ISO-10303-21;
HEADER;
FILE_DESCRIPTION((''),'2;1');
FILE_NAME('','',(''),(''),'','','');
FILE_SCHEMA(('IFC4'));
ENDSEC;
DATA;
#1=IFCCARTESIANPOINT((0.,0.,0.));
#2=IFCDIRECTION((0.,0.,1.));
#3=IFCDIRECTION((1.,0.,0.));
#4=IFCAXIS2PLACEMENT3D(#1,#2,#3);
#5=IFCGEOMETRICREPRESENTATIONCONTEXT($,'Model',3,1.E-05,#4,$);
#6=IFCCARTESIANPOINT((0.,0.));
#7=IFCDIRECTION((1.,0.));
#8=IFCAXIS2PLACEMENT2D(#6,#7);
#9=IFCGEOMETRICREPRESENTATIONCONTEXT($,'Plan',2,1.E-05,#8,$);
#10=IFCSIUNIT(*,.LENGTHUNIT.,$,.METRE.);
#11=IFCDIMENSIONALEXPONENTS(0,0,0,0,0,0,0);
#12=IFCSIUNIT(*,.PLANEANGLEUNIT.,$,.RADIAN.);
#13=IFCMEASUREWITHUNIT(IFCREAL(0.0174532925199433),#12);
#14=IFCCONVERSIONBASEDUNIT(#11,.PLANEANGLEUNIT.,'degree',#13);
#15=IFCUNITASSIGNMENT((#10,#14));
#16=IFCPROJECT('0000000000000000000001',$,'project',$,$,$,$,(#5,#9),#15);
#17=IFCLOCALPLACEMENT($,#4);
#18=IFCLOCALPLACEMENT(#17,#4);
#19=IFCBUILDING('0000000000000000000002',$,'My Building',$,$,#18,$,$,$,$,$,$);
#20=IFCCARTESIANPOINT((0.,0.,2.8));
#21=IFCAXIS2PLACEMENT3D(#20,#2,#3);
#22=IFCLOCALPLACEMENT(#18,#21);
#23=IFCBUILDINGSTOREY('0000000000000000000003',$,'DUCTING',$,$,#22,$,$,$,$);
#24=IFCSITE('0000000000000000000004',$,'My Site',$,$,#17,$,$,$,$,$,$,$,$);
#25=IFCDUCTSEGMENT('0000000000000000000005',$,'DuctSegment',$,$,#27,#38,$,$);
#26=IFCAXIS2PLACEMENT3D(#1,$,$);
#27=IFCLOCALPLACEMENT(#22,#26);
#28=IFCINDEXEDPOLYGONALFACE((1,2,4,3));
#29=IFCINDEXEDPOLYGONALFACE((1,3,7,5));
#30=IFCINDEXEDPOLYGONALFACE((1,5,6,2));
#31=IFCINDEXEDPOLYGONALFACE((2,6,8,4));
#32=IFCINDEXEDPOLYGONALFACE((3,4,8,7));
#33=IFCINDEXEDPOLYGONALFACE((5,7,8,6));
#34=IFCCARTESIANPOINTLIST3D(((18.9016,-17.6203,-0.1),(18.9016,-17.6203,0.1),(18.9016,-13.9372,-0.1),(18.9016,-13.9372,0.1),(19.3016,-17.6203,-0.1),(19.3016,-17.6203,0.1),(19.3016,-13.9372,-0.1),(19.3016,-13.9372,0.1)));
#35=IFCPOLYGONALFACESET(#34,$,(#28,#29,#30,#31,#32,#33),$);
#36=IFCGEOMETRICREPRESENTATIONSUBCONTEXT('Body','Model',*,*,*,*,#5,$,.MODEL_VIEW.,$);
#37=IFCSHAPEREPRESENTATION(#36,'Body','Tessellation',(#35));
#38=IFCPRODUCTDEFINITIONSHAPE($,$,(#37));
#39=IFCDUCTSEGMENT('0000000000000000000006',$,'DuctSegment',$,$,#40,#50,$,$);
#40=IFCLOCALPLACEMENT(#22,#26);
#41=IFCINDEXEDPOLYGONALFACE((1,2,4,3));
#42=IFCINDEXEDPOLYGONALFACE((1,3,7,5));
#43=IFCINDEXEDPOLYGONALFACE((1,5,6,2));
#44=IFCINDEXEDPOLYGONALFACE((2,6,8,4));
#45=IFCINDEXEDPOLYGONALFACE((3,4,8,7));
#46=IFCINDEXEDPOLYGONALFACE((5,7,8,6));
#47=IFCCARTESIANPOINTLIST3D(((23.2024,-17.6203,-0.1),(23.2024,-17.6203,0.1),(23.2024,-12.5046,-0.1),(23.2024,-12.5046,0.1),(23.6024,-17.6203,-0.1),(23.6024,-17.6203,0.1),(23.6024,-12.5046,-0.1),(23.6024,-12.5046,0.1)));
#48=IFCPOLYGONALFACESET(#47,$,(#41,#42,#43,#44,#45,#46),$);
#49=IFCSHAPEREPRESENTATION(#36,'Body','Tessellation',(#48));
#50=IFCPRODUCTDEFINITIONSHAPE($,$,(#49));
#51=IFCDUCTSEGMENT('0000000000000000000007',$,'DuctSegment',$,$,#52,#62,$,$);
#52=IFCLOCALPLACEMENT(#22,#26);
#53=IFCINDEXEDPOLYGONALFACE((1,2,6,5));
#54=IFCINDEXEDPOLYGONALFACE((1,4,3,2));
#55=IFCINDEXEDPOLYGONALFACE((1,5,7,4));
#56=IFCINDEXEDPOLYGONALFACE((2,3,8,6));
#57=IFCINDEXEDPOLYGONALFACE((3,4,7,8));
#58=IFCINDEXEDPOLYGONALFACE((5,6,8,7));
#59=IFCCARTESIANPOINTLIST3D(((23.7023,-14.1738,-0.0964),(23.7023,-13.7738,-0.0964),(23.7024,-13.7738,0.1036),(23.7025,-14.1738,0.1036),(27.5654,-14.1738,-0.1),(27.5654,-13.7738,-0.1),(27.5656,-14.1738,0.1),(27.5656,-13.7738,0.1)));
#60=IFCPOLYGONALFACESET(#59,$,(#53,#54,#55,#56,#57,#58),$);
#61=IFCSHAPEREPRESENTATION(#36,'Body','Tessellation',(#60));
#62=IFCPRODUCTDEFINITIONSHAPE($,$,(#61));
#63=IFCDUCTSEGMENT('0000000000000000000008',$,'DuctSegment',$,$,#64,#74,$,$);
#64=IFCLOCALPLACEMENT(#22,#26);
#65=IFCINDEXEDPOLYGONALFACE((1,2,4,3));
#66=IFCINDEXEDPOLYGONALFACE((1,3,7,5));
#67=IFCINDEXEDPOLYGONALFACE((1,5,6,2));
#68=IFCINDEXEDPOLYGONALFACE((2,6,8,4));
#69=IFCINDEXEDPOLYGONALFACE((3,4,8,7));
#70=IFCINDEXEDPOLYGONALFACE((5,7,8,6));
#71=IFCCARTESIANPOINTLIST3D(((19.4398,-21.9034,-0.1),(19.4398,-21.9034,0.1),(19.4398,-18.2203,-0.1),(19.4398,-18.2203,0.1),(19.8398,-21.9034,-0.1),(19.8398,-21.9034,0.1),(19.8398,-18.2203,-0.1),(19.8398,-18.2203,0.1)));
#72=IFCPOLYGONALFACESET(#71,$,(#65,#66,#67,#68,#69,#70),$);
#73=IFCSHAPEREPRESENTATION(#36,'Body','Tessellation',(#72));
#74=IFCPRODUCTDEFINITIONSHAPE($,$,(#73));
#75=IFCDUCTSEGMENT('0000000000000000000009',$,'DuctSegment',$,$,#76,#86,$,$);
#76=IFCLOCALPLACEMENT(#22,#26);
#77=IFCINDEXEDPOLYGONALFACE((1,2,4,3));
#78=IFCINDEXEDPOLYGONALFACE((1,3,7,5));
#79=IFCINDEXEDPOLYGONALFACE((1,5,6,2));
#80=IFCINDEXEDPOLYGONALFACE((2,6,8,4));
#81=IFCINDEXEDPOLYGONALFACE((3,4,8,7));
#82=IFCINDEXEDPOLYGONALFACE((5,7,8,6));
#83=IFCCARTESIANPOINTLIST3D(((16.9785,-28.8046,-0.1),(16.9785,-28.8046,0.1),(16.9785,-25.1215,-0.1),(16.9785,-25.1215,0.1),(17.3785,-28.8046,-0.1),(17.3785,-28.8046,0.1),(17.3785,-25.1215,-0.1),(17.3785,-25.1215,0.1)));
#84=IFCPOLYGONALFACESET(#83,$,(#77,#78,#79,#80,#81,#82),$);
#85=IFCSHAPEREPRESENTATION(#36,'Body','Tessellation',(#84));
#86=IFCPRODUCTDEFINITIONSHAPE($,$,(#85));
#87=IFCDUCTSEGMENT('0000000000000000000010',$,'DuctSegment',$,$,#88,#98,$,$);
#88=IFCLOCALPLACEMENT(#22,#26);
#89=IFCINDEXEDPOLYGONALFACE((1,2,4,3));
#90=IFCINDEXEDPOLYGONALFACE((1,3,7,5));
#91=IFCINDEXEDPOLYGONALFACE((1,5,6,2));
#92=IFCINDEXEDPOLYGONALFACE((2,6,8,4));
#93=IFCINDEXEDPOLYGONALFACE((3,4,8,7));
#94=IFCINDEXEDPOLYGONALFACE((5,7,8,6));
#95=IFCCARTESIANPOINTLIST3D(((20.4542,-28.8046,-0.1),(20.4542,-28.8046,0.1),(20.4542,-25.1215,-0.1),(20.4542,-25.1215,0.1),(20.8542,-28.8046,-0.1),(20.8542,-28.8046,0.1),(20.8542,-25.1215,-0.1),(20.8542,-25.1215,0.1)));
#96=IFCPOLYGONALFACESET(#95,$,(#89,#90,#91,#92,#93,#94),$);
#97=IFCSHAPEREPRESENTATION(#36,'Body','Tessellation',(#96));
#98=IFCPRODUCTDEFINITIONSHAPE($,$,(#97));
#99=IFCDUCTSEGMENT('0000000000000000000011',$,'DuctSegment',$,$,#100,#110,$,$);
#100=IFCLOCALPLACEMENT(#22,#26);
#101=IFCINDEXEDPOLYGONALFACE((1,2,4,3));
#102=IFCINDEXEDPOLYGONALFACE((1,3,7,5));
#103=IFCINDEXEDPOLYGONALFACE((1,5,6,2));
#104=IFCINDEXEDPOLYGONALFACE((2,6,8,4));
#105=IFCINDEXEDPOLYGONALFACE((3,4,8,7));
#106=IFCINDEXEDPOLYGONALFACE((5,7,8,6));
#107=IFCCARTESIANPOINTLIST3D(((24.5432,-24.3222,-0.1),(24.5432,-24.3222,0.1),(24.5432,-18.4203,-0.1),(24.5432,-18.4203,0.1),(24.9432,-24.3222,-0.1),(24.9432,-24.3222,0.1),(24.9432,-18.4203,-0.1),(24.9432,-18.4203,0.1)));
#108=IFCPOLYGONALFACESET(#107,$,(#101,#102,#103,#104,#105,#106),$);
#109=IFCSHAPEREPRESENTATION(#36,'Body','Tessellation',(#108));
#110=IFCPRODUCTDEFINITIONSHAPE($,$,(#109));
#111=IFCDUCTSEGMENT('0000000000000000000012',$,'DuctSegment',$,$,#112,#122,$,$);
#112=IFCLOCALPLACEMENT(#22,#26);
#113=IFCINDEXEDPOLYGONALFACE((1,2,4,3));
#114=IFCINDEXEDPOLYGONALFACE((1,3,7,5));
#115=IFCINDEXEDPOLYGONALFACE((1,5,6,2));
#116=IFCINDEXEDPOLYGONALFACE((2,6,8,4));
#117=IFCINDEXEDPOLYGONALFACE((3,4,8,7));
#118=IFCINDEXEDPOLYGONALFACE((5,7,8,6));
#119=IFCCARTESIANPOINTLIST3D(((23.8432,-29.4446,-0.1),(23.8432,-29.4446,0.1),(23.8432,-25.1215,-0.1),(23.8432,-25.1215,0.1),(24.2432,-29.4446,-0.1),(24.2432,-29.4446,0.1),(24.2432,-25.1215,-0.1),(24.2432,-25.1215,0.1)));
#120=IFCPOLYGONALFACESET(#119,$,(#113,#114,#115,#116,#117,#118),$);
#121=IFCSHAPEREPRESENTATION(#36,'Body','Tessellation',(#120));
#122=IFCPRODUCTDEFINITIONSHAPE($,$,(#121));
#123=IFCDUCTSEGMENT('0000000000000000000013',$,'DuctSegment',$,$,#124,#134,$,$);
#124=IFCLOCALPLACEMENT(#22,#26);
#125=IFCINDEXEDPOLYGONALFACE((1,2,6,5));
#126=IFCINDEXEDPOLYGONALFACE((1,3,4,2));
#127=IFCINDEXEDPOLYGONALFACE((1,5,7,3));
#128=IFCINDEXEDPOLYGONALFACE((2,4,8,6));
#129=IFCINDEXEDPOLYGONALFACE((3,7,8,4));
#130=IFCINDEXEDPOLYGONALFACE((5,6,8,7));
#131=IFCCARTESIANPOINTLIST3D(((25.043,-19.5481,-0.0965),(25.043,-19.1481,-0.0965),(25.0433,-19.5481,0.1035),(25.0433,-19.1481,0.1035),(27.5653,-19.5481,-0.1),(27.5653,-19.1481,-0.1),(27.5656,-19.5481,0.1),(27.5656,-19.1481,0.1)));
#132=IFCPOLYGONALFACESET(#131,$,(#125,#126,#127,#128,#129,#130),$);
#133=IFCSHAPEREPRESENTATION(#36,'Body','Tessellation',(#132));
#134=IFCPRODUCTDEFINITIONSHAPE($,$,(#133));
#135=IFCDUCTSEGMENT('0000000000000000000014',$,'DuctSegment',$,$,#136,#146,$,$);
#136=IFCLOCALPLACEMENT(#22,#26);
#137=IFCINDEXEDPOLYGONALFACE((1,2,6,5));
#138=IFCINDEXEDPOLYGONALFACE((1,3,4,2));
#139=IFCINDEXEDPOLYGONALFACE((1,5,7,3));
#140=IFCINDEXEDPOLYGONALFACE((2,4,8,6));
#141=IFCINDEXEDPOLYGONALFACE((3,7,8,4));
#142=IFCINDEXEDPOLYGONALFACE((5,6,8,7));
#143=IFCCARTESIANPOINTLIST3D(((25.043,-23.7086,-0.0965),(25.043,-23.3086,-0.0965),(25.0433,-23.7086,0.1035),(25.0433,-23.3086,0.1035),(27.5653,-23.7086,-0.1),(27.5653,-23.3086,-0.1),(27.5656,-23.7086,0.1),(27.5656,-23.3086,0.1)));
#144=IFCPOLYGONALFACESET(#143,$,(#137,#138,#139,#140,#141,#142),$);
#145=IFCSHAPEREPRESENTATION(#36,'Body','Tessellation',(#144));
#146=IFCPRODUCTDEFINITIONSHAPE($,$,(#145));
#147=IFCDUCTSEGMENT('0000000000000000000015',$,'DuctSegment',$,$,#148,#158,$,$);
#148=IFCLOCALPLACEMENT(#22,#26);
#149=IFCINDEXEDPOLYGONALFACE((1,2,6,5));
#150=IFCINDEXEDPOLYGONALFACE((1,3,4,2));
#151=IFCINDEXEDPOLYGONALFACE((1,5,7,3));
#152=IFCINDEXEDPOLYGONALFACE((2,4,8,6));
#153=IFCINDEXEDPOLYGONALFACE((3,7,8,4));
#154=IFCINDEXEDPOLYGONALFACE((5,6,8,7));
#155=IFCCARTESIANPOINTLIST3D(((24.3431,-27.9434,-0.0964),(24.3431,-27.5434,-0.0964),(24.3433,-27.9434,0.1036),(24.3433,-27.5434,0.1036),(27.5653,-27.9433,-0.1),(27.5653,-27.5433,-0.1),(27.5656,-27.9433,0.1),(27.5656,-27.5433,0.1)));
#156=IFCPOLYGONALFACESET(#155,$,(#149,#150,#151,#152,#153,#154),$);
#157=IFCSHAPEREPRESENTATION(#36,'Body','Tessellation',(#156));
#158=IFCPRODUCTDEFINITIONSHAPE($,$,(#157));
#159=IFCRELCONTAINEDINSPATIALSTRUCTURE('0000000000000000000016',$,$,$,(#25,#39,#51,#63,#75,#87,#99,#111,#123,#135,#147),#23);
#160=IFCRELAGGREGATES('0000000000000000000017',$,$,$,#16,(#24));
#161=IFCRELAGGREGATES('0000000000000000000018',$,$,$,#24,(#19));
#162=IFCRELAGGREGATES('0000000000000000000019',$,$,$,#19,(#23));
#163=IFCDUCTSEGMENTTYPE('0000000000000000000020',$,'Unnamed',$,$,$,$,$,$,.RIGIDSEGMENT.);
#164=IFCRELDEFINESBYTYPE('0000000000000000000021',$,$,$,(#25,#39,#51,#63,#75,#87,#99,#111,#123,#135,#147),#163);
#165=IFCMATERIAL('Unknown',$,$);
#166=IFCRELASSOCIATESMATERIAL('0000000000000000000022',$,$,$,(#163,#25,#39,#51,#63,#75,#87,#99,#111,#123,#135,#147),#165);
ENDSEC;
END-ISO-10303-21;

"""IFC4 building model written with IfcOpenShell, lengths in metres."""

from ifc_helpers import new_model, entity, si_unit, converted_unit, frame, origin_with_axes, origin_2d_with_axis, place, context, subcontext, project, spatial, rectangle, extrude, material, material_profile, profile_set, profile_usage, type_object, element, save


model = new_model("IFC4")

# Units and contexts
model_context = context("Model", 3, precision=1e-05, world=origin_with_axes())
plan_context = context("Plan", 2, precision=1e-05, world=origin_2d_with_axis())
body_context = subcontext(model_context, "Body", "Model", "MODEL_VIEW")
ifc_project = project(units=[si_unit("LENGTHUNIT", "METRE"), converted_unit("PLANEANGLEUNIT", "degree", entity("IfcReal", 0.0174532925199433), si_unit("PLANEANGLEUNIT", "RADIAN"), dimensions=[0, 0, 0, 0, 0, 0, 0])], contexts=[model_context, plan_context])

# Site, building, storey
site_placement = place(None, origin_with_axes())
site = spatial("IfcSite", under=ifc_project, at=site_placement, Name="My Site")
building_placement = place(site_placement, origin_with_axes())
building = spatial("IfcBuilding", under=site, at=building_placement, Name="My Building")
storey_placement = place(building_placement, frame((0.0, 0.0, 2.8), z_axis=(0.0, 0.0, 1.0), x_axis=(1.0, 0.0, 0.0)))
storey = spatial("IfcBuildingStorey", under=building, at=storey_placement, Name="DUCTING")

# Duct segments
ifc_material = material(Name="Unknown")
ifc_material_profile_1 = material_profile(ifc_material, rectangle(XDim=0.4, YDim=0.2))
ifc_profile_set_1 = profile_set([ifc_material_profile_1])
ifc_profile_usage_1 = profile_usage(ifc_profile_set_1, cardinal=5)
duct_segment_type = type_object("IfcDuctSegmentType", Name="Unnamed", PredefinedType="RIGIDSEGMENT", material=ifc_profile_set_1)
duct_segment_1_placement = place(storey_placement, frame((19.1016, -13.9372, 0.0), z_axis=(0.0, -1.0, 0.0), x_axis=(1.0, 0.0, 0.0)))
element("IfcDuctSegment", 1, at=duct_segment_1_placement, inside=storey, type_object=duct_segment_type, material=ifc_profile_usage_1, Name="DuctSegment", context=body_context, shape_type="SweptSolid", body=[
    extrude(rectangle(XDim=0.4, YDim=0.2), origin_with_axes(), (0.0, 0.0, 1.0), 3.6831),
])
ifc_profile_usage_2 = profile_usage(ifc_profile_set_1, cardinal=5)
duct_segment_2_placement = place(storey_placement, frame((23.4024, -12.5046, 0.0), z_axis=(0.0, -1.0, 0.0), x_axis=(1.0, 0.0, 0.0)))
element("IfcDuctSegment", 2, at=duct_segment_2_placement, inside=storey, type_object=duct_segment_type, material=ifc_profile_usage_2, Name="DuctSegment", context=body_context, shape_type="SweptSolid", body=[
    extrude(rectangle(XDim=0.4, YDim=0.2), origin_with_axes(), (0.0, 0.0, 1.0), 5.1156),
])
ifc_profile_usage_3 = profile_usage(ifc_profile_set_1, cardinal=5)
duct_segment_3_placement = place(storey_placement, frame((27.5655, -13.9738, 0.0), z_axis=(-1.0, -0.000006, 0.00093), x_axis=(0.000006, -1.0, 0.0)))
element("IfcDuctSegment", 3, at=duct_segment_3_placement, inside=storey, type_object=duct_segment_type, material=ifc_profile_usage_3, Name="DuctSegment", context=body_context, shape_type="SweptSolid", body=[
    extrude(rectangle(XDim=0.4, YDim=0.2), origin_with_axes(), (0.0, 0.0, 1.0), 3.8631),
])
ifc_profile_usage_4 = profile_usage(ifc_profile_set_1, cardinal=5)
duct_segment_4_placement = place(storey_placement, frame((19.6398, -21.9034, 0.0), z_axis=(0.0, 1.0, 0.0), x_axis=(-1.0, 0.0, 0.0)))
element("IfcDuctSegment", 4, at=duct_segment_4_placement, inside=storey, type_object=duct_segment_type, material=ifc_profile_usage_4, Name="DuctSegment", context=body_context, shape_type="SweptSolid", body=[
    extrude(rectangle(XDim=0.4, YDim=0.2), origin_with_axes(), (0.0, 0.0, 1.0), 3.6831),
])
ifc_profile_usage_5 = profile_usage(ifc_profile_set_1, cardinal=5)
duct_segment_5_placement = place(storey_placement, frame((17.1785, -28.8046, 0.0), z_axis=(0.0, 1.0, 0.0), x_axis=(-1.0, 0.0, 0.0)))
element("IfcDuctSegment", 5, at=duct_segment_5_placement, inside=storey, type_object=duct_segment_type, material=ifc_profile_usage_5, Name="DuctSegment", context=body_context, shape_type="SweptSolid", body=[
    extrude(rectangle(XDim=0.4, YDim=0.2), origin_with_axes(), (0.0, 0.0, 1.0), 3.6831),
])
ifc_profile_usage_6 = profile_usage(ifc_profile_set_1, cardinal=5)
duct_segment_6_placement = place(storey_placement, frame((20.6542, -28.8046, 0.0), z_axis=(0.0, 1.0, 0.0), x_axis=(-1.0, 0.0, 0.0)))
element("IfcDuctSegment", 6, at=duct_segment_6_placement, inside=storey, type_object=duct_segment_type, material=ifc_profile_usage_6, Name="DuctSegment", context=body_context, shape_type="SweptSolid", body=[
    extrude(rectangle(XDim=0.4, YDim=0.2), origin_with_axes(), (0.0, 0.0, 1.0), 3.6831),
])
ifc_profile_usage_7 = profile_usage(ifc_profile_set_1, cardinal=5)
duct_segment_7_placement = place(storey_placement, frame((24.7432, -18.4203, 0.0), z_axis=(0.0, -1.0, 0.0), x_axis=(1.0, 0.0, 0.0)))
element("IfcDuctSegment", 7, at=duct_segment_7_placement, inside=storey, type_object=duct_segment_type, material=ifc_profile_usage_7, Name="DuctSegment", context=body_context, shape_type="SweptSolid", body=[
    extrude(rectangle(XDim=0.4, YDim=0.2), origin_with_axes(), (0.0, 0.0, 1.0), 5.9019),
])
ifc_profile_usage_8 = profile_usage(ifc_profile_set_1, cardinal=5)
duct_segment_8_placement = place(storey_placement, frame((24.0432, -29.4446, 0.0), z_axis=(0.0, 1.0, 0.0), x_axis=(-1.0, 0.0, 0.0)))
element("IfcDuctSegment", 8, at=duct_segment_8_placement, inside=storey, type_object=duct_segment_type, material=ifc_profile_usage_8, Name="DuctSegment", context=body_context, shape_type="SweptSolid", body=[
    extrude(rectangle(XDim=0.4, YDim=0.2), origin_with_axes(), (0.0, 0.0, 1.0), 4.3231),
])
ifc_profile_usage_9 = profile_usage(ifc_profile_set_1, cardinal=5)
duct_segment_9_placement = place(storey_placement, frame((27.5655, -19.3481, 0.0), z_axis=(-0.999999, -0.000009, 0.001405), x_axis=(0.000009, -1.0, 0.0)))
element("IfcDuctSegment", 9, at=duct_segment_9_placement, inside=storey, type_object=duct_segment_type, material=ifc_profile_usage_9, Name="DuctSegment", context=body_context, shape_type="SweptSolid", body=[
    extrude(rectangle(XDim=0.4, YDim=0.2), origin_with_axes(), (0.0, 0.0, 1.0), 2.5223),
])
ifc_profile_usage_10 = profile_usage(ifc_profile_set_1, cardinal=5)
duct_segment_10_placement = place(storey_placement, frame((27.5655, -23.5086, 0.0), z_axis=(-0.999999, -0.000009, 0.001405), x_axis=(0.000009, -1.0, 0.0)))
element("IfcDuctSegment", 10, at=duct_segment_10_placement, inside=storey, type_object=duct_segment_type, material=ifc_profile_usage_10, Name="DuctSegment", context=body_context, shape_type="SweptSolid", body=[
    extrude(rectangle(XDim=0.4, YDim=0.2), origin_with_axes(), (0.0, 0.0, 1.0), 2.5223),
])
ifc_profile_usage_11 = profile_usage(ifc_profile_set_1, cardinal=5)
duct_segment_11_placement = place(storey_placement, frame((27.5655, -27.7433, 0.0), z_axis=(-0.999999, -0.000008, 0.001109), x_axis=(0.000008, -1.0, 0.0)))
element("IfcDuctSegment", 11, at=duct_segment_11_placement, inside=storey, type_object=duct_segment_type, material=ifc_profile_usage_11, Name="DuctSegment", context=body_context, shape_type="SweptSolid", body=[
    extrude(rectangle(XDim=0.4, YDim=0.2), origin_with_axes(), (0.0, 0.0, 1.0), 3.2223),
])

save(model, "model.ifc")
